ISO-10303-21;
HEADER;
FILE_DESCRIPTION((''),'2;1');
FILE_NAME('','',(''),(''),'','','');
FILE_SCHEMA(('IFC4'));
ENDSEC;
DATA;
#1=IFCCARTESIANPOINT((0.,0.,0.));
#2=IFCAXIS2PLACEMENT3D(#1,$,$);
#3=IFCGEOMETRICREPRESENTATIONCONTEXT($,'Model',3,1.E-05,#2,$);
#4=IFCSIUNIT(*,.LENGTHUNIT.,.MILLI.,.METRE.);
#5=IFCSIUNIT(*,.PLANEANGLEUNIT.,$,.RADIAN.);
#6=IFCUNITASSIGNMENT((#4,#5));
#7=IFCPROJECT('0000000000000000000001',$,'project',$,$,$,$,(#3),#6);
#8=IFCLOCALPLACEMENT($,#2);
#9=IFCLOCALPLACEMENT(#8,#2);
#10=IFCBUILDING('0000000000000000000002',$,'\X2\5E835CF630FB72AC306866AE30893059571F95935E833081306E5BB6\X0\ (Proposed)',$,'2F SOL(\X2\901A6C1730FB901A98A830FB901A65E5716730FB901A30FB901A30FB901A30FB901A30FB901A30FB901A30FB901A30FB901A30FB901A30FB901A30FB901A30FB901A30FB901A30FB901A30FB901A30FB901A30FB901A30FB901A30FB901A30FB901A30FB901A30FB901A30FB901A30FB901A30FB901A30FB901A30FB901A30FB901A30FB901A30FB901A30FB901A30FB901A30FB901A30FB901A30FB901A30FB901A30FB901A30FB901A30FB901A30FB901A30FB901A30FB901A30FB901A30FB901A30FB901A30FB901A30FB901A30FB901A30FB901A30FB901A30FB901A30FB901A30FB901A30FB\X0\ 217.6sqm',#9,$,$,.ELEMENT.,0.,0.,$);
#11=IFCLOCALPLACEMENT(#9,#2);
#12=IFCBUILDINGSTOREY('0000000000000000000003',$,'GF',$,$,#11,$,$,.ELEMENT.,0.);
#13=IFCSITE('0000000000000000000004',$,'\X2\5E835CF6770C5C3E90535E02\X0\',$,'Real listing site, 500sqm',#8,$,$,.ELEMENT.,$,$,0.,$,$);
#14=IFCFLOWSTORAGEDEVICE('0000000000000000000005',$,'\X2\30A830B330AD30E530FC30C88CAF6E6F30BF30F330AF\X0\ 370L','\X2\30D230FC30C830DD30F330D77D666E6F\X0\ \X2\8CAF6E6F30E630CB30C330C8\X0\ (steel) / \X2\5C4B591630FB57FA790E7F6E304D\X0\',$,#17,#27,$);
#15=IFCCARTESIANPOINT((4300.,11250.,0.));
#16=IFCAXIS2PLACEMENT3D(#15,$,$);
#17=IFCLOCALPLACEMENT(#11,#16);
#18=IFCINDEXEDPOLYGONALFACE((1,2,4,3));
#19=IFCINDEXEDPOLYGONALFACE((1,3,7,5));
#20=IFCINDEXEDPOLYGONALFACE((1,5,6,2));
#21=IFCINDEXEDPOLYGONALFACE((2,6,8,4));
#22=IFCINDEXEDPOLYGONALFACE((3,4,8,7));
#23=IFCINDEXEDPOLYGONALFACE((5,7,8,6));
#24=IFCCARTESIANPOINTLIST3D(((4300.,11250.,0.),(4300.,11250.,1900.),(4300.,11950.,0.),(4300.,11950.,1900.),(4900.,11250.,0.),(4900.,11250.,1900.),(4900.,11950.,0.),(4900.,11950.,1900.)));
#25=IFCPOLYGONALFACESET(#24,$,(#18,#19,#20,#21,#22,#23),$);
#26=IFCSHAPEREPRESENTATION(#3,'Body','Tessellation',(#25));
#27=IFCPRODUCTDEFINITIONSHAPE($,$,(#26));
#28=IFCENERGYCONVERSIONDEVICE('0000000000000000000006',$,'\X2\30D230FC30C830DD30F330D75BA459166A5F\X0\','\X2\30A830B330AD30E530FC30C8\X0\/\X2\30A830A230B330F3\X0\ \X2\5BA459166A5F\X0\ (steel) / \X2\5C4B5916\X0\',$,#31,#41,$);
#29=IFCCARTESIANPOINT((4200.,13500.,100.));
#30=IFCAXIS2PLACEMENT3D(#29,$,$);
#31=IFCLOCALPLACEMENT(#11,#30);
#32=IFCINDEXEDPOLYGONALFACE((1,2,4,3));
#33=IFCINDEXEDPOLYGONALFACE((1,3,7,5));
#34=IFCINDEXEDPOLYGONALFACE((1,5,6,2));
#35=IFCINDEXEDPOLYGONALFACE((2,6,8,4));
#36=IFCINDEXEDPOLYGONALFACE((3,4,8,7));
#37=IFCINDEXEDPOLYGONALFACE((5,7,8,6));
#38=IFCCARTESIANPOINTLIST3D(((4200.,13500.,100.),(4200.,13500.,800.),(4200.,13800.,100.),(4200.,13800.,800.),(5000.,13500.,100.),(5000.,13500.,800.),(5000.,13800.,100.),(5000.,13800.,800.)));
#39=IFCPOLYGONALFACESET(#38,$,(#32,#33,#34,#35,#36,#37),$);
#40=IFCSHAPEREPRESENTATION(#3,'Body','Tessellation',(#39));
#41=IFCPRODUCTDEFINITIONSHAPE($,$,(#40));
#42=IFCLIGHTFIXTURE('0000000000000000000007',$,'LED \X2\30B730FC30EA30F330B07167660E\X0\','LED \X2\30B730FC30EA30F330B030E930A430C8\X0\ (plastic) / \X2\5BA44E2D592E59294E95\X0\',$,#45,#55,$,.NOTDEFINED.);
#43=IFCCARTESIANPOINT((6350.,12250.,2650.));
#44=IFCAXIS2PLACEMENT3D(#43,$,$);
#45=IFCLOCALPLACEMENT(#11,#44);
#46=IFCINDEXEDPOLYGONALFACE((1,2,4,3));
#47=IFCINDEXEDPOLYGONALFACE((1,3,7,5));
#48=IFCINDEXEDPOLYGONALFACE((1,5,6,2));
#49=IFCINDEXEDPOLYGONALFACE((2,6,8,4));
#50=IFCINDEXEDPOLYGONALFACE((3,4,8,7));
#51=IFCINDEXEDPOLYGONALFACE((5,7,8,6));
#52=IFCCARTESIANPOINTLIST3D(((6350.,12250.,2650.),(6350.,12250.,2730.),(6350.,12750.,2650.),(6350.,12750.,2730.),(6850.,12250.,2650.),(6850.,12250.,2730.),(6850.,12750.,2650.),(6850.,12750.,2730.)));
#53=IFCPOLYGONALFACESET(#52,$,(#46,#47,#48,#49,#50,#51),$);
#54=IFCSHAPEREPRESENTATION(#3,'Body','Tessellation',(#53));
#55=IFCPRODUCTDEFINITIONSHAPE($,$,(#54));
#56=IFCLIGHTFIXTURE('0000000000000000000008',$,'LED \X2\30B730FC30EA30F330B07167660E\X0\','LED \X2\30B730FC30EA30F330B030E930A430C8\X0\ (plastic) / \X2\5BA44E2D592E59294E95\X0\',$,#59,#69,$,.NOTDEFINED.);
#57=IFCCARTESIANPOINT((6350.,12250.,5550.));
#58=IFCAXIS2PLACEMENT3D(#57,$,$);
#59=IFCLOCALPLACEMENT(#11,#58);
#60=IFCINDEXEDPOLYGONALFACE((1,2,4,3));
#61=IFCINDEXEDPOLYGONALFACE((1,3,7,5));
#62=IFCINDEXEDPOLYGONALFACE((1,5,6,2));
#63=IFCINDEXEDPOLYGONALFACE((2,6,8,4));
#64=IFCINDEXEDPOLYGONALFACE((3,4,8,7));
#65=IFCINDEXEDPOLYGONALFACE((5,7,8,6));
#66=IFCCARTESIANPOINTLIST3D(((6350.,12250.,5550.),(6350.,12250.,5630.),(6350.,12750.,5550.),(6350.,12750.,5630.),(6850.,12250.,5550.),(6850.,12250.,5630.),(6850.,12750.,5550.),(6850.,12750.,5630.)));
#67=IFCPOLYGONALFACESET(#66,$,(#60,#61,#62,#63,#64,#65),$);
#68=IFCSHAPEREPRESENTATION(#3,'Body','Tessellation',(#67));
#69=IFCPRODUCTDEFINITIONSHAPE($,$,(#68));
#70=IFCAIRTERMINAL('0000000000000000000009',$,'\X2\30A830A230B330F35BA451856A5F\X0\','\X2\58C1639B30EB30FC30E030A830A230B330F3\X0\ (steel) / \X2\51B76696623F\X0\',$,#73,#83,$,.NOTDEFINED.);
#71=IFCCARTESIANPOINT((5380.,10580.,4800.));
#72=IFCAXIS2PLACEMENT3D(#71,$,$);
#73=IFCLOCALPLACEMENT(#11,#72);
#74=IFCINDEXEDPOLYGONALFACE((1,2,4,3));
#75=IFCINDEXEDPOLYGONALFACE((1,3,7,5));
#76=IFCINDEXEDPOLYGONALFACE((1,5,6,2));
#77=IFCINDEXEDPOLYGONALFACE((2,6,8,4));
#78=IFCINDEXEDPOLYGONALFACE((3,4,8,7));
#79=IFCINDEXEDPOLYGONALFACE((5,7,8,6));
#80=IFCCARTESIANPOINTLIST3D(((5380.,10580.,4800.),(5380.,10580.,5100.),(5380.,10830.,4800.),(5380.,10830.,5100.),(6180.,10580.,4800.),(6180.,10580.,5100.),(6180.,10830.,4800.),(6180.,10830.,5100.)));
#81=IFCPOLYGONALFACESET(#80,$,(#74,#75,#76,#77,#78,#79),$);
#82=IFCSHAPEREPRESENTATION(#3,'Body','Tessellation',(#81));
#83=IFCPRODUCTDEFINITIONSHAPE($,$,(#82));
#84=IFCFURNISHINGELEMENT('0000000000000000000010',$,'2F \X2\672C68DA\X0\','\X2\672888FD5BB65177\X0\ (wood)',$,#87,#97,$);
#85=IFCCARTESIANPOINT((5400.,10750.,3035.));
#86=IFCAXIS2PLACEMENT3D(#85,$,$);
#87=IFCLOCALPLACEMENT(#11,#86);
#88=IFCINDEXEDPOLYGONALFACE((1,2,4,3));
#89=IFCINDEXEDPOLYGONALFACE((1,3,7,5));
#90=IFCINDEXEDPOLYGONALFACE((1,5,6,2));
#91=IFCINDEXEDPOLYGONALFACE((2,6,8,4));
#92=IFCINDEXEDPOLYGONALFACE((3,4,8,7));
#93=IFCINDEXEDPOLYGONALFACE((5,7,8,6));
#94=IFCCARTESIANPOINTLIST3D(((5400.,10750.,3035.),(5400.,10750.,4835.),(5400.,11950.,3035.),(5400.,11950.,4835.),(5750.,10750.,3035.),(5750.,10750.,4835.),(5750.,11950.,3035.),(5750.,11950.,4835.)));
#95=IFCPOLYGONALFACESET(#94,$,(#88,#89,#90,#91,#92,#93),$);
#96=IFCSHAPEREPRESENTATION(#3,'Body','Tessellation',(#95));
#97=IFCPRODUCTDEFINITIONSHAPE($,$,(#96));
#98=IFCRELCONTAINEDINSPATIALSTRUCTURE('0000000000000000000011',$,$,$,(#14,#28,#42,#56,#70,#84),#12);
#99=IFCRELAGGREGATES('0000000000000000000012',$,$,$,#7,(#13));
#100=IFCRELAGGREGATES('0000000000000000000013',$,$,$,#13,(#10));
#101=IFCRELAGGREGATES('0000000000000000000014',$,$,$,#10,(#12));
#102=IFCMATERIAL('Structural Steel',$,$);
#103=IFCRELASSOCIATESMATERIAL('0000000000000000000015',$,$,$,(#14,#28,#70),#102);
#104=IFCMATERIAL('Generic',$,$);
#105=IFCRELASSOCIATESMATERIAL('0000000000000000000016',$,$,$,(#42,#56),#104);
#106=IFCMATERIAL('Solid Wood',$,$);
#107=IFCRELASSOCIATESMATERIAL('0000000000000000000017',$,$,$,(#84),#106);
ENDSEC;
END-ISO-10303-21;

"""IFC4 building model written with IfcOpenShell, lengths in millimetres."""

from ifc_helpers import new_model, si_unit, frame, frame_2d, origin, place, context, project, spatial, rectangle, extrude, material, element, save


model = new_model("IFC4")

# Units and contexts
model_context = context("Model", 3, precision=1e-05, world=origin())
ifc_project = project(units=[si_unit("LENGTHUNIT", "METRE", prefix="MILLI"), si_unit("PLANEANGLEUNIT", "RADIAN")], contexts=[model_context])

# Site, building, storey
site_placement = place(None, origin())
site = spatial("IfcSite", under=ifc_project, at=site_placement, Name="広島県尾道市", ObjectType="Real listing site, 500sqm", CompositionType="ELEMENT", RefElevation=0.0)
building_placement = place(site_placement, origin())
building = spatial("IfcBuilding", under=site, at=building_placement, Name="広島・犬と暮らす土間広めの家 (Proposed)", ObjectType="2F SOL(通気・通風・通日照・通・通・通・通・通・通・通・通・通・通・通・通・通・通・通・通・通・通・通・通・通・通・通・通・通・通・通・通・通・通・通・通・通・通・通・通・通・通・通・通・通・通・通・通・通・通・通・通・通・通・通・通・通・ 217.6sqm", CompositionType="ELEMENT", ElevationOfRefHeight=0.0, ElevationOfTerrain=0.0)
storey_placement = place(building_placement, origin())
storey = spatial("IfcBuildingStorey", under=building, at=storey_placement, Name="GF", CompositionType="ELEMENT", Elevation=0.0)

# Shared definitions
ifc_material_1 = material(Name="Solid Wood")

# Shared definitions
ifc_material_2 = material(Name="Structural Steel")

# Shared definitions
ifc_material_3 = material(Name="Generic")

# Flow storage device
flow_storage_device_placement = place(storey_placement, frame((4300.0, 11250.0, 0.0)))
element("IfcFlowStorageDevice", 1, at=flow_storage_device_placement, inside=storey, material=ifc_material_2, Name="エコキュート貯湯タンク 370L", Description="ヒートポンプ給湯 貯湯ユニット (steel) / 屋外・基礎置き", context=model_context, shape_type="SweptSolid", body=[
    extrude(rectangle(XDim=600.0, YDim=700.0, at=frame_2d((300.0, 350.0))), frame((4300.0, 11250.0, 0.0)), (0.0, 0.0, 1.0), 1900.0),
])

# Energy conversion device
energy_conversion_device_placement = place(storey_placement, frame((4200.0, 13500.0, 100.0)))
element("IfcEnergyConversionDevice", 2, at=energy_conversion_device_placement, inside=storey, material=ifc_material_2, Name="ヒートポンプ室外機", Description="エコキュート/エアコン 室外機 (steel) / 屋外", context=model_context, shape_type="SweptSolid", body=[
    extrude(rectangle(XDim=800.0, YDim=300.0, at=frame_2d((400.0, 150.0))), frame((4200.0, 13500.0, 100.0)), (0.0, 0.0, 1.0), 700.0),
])

# Light fixtures
light_fixture_1_placement = place(storey_placement, frame((6350.0, 12250.0, 2650.0)))
element("IfcLightFixture", 3, at=light_fixture_1_placement, inside=storey, material=ifc_material_3, Name="LED シーリング照明", Description="LED シーリングライト (plastic) / 室中央天井", PredefinedType="NOTDEFINED", context=model_context, shape_type="SweptSolid", body=[
    extrude(rectangle(XDim=500.0, YDim=500.0, at=frame_2d((250.0, 250.0))), frame((6350.0, 12250.0, 2650.0)), (0.0, 0.0, 1.0), 80.0),
])
light_fixture_2_placement = place(storey_placement, frame((6350.0, 12250.0, 5550.0)))
element("IfcLightFixture", 4, at=light_fixture_2_placement, inside=storey, material=ifc_material_3, Name="LED シーリング照明", Description="LED シーリングライト (plastic) / 室中央天井", PredefinedType="NOTDEFINED", context=model_context, shape_type="SweptSolid", body=[
    extrude(rectangle(XDim=500.0, YDim=500.0, at=frame_2d((250.0, 250.0))), frame((6350.0, 12250.0, 5550.0)), (0.0, 0.0, 1.0), 80.0),
])

# Air terminal
air_terminal_placement = place(storey_placement, frame((5380.0, 10580.0, 4800.0)))
element("IfcAirTerminal", 5, at=air_terminal_placement, inside=storey, material=ifc_material_2, Name="エアコン室内機", Description="壁掛ルームエアコン (steel) / 冷暖房", PredefinedType="NOTDEFINED", context=model_context, shape_type="SweptSolid", body=[
    extrude(rectangle(XDim=800.0, YDim=250.0, at=frame_2d((400.0, 125.0))), frame((5380.0, 10580.0, 4800.0)), (0.0, 0.0, 1.0), 300.0),
])

# Furnishing element
furnishing_placement = place(storey_placement, frame((5400.0, 10750.0, 3035.0)))
element("IfcFurnishingElement", 6, at=furnishing_placement, inside=storey, material=ifc_material_1, Name="2F 本棚", Description="木製家具 (wood)", context=model_context, shape_type="SweptSolid", body=[
    extrude(rectangle(XDim=350.0, YDim=1200.0, at=frame_2d((175.0, 600.0))), frame((5400.0, 10750.0, 3035.0)), (0.0, 0.0, 1.0), 1800.0),
])

save(model, "model.ifc")
